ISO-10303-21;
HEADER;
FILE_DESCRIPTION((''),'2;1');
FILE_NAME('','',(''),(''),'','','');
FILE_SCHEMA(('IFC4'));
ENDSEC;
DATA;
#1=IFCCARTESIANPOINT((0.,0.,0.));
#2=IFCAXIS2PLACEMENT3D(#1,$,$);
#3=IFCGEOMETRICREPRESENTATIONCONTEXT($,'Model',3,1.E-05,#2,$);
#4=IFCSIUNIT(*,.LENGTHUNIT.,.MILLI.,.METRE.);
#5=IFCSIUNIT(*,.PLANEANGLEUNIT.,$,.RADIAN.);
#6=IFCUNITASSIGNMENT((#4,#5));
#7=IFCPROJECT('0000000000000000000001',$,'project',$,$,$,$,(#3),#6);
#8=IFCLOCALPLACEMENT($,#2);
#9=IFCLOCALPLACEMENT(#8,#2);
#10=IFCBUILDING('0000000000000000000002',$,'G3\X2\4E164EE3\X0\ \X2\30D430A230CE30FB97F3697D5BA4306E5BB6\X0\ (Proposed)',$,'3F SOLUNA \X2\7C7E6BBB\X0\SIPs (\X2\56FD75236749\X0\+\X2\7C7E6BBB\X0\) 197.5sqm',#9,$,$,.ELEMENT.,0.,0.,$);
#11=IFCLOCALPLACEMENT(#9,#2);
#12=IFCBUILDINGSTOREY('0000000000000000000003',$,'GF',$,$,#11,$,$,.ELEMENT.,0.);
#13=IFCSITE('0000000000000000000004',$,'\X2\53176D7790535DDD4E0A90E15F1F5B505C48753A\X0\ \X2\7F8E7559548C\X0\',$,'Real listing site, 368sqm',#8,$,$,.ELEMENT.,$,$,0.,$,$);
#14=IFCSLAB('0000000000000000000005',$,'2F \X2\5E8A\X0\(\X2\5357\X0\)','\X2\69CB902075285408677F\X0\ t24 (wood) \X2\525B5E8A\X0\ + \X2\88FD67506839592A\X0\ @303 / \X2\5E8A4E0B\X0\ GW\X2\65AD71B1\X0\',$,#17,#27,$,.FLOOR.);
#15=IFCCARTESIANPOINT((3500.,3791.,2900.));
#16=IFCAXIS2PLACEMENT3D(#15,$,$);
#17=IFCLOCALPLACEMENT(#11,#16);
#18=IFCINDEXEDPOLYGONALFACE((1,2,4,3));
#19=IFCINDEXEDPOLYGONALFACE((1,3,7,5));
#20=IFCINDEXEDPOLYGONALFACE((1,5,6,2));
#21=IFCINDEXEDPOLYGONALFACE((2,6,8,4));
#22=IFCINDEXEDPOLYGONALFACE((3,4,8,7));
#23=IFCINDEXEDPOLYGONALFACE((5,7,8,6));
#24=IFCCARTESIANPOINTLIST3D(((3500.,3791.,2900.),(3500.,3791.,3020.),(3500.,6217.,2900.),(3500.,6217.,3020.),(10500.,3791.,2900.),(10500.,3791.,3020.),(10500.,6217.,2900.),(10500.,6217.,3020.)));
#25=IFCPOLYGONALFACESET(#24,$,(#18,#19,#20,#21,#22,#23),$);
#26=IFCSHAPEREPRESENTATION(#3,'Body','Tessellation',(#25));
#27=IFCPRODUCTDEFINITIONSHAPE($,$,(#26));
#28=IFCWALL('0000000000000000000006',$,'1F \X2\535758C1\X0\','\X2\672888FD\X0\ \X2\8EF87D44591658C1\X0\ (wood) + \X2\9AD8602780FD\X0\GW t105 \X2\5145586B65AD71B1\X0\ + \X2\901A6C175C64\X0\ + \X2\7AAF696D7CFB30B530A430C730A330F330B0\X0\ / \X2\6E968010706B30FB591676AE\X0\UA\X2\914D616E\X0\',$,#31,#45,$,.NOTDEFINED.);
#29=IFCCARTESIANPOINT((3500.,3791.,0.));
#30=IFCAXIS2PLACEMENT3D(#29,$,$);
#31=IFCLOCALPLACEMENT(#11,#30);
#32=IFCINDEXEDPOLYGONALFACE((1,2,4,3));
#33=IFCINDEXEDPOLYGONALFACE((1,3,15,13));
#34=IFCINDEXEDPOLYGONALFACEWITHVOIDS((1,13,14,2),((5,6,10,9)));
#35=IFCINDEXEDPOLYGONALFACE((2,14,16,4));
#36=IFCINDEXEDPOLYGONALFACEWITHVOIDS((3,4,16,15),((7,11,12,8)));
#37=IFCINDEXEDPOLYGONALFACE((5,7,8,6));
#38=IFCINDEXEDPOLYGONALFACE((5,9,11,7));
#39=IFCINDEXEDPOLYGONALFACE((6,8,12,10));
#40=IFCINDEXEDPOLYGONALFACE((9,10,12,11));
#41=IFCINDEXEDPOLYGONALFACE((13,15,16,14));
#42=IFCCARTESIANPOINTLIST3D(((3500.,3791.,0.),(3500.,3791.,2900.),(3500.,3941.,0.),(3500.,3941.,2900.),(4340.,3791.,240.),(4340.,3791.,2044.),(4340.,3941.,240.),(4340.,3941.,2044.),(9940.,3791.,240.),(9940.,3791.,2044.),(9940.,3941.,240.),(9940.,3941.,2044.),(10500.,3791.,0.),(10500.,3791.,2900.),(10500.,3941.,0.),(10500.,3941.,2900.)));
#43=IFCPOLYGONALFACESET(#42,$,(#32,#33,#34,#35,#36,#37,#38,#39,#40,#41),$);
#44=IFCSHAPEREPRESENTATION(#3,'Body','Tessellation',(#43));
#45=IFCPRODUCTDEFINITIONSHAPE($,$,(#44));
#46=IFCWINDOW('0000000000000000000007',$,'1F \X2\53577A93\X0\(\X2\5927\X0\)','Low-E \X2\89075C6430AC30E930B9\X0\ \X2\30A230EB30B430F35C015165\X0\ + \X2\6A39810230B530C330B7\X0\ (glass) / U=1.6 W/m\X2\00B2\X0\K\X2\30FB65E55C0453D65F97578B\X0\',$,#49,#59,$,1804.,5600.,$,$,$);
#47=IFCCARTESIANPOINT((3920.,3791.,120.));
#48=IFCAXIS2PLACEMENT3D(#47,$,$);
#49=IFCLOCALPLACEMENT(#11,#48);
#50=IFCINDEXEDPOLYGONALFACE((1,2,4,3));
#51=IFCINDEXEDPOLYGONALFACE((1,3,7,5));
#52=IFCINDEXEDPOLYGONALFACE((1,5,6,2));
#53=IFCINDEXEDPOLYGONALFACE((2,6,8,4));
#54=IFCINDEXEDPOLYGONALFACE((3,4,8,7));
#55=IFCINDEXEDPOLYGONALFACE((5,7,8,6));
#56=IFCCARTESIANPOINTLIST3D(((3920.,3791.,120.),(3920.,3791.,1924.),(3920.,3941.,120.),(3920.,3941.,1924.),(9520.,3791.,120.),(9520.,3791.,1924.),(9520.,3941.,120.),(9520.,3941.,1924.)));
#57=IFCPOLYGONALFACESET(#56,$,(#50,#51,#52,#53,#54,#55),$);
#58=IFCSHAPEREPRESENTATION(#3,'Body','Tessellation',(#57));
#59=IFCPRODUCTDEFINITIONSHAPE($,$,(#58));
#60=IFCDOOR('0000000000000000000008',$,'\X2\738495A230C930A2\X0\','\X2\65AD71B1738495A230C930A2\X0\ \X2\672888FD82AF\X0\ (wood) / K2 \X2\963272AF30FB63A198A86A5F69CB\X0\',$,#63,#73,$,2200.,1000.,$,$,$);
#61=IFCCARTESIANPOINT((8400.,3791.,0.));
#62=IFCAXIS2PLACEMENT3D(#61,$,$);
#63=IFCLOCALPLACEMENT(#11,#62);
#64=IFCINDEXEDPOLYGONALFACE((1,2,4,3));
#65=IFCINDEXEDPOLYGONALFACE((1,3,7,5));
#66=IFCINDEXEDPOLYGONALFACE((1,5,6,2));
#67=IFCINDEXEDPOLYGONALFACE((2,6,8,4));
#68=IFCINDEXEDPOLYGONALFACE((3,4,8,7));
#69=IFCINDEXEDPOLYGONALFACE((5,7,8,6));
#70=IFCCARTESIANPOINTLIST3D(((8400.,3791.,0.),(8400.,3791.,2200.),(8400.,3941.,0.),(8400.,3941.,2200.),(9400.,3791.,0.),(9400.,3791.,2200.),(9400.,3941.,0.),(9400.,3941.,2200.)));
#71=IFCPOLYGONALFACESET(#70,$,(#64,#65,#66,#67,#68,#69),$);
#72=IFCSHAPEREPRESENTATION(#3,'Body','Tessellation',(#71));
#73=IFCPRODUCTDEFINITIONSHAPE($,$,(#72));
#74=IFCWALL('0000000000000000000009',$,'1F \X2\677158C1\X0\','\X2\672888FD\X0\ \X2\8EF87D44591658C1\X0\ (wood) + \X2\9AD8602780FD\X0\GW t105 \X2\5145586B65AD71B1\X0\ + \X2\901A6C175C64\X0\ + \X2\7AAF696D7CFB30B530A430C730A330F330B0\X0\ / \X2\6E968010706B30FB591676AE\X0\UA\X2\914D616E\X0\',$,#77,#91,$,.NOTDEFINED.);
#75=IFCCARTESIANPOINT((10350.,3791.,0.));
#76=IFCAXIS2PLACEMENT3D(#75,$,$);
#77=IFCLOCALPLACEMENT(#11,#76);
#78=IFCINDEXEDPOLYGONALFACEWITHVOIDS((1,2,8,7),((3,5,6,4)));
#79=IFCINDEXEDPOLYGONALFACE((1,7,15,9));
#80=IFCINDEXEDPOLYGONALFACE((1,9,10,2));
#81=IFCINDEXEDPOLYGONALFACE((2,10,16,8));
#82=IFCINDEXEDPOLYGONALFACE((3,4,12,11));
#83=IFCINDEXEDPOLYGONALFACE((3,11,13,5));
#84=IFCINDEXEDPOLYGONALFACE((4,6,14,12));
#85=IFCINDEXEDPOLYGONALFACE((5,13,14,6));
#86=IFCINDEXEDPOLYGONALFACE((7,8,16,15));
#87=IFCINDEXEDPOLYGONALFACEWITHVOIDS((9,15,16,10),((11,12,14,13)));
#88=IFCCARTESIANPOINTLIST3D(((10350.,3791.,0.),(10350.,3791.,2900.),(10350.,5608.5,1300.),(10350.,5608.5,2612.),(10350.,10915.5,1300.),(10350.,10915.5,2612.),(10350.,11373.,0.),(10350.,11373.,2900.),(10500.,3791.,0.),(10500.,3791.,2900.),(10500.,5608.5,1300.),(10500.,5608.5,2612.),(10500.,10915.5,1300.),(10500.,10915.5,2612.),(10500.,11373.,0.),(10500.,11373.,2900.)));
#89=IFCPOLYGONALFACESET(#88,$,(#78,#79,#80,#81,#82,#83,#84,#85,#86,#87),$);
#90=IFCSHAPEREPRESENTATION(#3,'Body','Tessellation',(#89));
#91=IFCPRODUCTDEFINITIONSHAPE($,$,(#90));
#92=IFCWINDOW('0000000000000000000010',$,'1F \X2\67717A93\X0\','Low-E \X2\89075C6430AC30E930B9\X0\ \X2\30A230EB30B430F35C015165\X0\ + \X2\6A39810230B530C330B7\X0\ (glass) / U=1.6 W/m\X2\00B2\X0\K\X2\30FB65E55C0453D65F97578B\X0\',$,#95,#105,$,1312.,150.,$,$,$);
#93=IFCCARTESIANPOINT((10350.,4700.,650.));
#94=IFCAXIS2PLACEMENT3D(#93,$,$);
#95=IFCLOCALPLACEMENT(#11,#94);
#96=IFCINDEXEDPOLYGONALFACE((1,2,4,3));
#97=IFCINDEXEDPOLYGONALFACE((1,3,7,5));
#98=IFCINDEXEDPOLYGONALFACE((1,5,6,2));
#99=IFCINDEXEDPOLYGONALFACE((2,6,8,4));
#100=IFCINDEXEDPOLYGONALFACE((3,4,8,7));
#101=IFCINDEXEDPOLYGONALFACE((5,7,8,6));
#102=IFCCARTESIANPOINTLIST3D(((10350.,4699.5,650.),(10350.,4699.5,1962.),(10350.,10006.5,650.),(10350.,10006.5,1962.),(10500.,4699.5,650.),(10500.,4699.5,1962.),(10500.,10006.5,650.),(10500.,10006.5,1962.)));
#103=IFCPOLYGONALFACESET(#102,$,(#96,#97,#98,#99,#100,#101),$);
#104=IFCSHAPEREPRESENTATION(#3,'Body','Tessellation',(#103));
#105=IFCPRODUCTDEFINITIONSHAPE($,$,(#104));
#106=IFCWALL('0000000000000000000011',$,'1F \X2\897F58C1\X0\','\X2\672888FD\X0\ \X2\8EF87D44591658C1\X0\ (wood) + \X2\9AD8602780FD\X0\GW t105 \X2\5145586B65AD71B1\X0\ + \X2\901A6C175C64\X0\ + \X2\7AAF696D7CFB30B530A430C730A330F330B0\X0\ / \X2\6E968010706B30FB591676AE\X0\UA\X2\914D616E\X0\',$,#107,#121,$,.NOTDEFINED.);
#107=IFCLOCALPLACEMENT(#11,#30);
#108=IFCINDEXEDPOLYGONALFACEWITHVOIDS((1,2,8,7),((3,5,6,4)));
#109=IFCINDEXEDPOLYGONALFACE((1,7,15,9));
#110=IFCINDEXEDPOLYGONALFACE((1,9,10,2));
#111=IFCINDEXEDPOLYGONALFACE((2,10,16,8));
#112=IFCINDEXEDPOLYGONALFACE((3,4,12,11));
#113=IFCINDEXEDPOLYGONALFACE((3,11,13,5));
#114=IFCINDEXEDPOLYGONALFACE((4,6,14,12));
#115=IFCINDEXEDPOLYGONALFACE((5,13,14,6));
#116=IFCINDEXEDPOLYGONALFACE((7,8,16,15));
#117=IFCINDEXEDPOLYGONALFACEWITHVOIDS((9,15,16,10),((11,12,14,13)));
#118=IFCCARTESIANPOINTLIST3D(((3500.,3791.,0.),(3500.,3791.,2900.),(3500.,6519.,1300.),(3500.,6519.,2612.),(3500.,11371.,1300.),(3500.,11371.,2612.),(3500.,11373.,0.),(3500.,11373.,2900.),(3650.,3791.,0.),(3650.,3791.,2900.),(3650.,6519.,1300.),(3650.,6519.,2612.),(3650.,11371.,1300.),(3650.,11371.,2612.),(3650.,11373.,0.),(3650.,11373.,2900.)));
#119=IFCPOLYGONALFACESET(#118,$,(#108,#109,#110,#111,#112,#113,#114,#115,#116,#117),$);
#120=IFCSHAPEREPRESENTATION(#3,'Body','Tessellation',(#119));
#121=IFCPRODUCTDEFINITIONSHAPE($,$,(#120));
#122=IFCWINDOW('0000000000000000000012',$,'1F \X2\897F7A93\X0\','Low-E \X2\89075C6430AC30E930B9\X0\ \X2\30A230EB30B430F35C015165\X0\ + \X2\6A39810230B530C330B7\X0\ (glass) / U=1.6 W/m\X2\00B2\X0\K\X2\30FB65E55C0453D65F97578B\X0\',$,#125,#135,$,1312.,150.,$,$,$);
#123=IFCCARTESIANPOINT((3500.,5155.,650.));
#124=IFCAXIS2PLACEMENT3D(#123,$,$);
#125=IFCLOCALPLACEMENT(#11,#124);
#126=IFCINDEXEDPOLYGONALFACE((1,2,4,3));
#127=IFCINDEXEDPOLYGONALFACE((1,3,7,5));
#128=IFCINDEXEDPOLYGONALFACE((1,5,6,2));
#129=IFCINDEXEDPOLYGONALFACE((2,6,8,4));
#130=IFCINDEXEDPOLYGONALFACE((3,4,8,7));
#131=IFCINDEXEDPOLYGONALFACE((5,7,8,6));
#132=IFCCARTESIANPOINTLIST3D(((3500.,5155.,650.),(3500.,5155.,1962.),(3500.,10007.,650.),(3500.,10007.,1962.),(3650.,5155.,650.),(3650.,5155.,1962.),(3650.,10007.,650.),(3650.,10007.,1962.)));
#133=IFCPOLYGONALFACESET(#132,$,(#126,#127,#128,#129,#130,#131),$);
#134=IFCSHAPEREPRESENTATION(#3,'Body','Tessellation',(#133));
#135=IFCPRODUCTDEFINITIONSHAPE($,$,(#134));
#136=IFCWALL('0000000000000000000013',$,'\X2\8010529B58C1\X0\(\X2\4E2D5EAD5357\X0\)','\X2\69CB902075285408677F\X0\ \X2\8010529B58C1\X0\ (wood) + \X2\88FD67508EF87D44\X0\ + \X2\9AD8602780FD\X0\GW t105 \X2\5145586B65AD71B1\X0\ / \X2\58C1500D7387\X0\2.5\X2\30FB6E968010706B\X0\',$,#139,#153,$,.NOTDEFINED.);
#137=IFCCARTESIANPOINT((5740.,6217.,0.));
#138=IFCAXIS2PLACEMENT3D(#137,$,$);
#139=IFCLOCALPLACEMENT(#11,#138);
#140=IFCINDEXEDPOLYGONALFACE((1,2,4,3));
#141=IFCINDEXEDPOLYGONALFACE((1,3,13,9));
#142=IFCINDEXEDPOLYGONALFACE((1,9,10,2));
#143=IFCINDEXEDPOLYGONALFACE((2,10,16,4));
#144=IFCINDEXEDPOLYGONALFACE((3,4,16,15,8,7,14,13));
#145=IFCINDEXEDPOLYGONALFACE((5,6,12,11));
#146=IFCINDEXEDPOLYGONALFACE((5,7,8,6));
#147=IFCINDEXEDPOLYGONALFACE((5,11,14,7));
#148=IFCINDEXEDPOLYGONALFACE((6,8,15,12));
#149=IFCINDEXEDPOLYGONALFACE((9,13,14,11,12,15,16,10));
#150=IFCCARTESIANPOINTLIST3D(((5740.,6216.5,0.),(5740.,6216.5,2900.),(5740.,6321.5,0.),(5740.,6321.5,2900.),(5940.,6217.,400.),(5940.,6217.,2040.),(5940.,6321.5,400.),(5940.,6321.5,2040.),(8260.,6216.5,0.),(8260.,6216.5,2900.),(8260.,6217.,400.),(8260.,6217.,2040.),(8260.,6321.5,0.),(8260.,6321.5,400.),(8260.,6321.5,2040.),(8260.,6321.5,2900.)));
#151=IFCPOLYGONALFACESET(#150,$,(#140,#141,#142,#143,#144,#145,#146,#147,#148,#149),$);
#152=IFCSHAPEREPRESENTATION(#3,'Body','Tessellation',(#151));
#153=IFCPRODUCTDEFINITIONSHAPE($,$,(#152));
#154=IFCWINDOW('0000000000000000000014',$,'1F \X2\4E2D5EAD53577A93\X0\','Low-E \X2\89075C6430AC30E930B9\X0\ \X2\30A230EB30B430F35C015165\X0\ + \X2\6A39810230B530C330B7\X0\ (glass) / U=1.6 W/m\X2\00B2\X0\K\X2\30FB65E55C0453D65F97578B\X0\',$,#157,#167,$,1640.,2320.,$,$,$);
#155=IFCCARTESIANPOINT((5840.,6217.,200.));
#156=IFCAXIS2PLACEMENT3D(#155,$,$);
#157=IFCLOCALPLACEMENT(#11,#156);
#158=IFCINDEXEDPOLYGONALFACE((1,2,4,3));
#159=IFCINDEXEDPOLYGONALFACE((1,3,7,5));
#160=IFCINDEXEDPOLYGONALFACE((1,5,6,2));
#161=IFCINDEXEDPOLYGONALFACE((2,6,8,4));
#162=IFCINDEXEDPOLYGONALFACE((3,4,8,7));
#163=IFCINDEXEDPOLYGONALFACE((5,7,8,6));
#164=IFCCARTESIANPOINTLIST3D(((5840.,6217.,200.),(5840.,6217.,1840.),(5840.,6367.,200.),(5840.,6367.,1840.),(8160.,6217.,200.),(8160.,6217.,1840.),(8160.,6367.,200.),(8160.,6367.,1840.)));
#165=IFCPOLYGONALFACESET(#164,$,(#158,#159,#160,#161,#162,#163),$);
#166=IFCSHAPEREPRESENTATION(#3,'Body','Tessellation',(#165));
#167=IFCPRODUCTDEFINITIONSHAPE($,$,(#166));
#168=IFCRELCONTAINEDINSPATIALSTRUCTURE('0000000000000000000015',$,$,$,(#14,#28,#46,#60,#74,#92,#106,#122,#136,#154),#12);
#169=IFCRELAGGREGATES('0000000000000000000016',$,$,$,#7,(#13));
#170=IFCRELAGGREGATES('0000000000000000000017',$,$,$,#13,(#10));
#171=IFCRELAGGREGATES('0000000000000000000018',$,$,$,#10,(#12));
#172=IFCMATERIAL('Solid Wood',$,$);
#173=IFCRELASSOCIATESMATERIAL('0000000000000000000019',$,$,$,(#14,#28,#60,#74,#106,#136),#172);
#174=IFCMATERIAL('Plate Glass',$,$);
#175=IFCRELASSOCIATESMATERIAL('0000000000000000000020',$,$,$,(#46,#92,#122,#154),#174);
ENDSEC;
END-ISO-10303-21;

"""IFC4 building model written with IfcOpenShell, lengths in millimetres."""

from ifc_helpers import new_model, si_unit, frame, frame_2d, origin, place, context, project, spatial, rectangle, extrude, material, element, fill, save


model = new_model("IFC4")

# Units and contexts
model_context = context("Model", 3, precision=1e-05, world=origin())
ifc_project = project(units=[si_unit("LENGTHUNIT", "METRE", prefix="MILLI"), si_unit("PLANEANGLEUNIT", "RADIAN")], contexts=[model_context])

# Site, building, storey
site_placement = place(None, origin())
site = spatial("IfcSite", under=ifc_project, at=site_placement, Name="北海道川上郡弟子屈町 美留和", ObjectType="Real listing site, 368sqm", CompositionType="ELEMENT", RefElevation=0.0)
building_placement = place(site_placement, origin())
building = spatial("IfcBuilding", under=site, at=building_placement, Name="G3世代 ピアノ・音楽室の家 (Proposed)", ObjectType="3F SOLUNA 籾殻SIPs (国産杉+籾殻) 197.5sqm", CompositionType="ELEMENT", ElevationOfRefHeight=0.0, ElevationOfTerrain=0.0)
storey_placement = place(building_placement, origin())
storey = spatial("IfcBuildingStorey", under=building, at=storey_placement, Name="GF", CompositionType="ELEMENT", Elevation=0.0)

# Slab
ifc_material_1 = material(Name="Solid Wood")
slab_1_placement = place(storey_placement, frame((3500.0, 3791.0, 2900.0)))
element("IfcSlab", 1, at=slab_1_placement, inside=storey, material=ifc_material_1, Name="2F 床(南)", Description="構造用合板 t24 (wood) 剛床 + 製材根太 @303 / 床下 GW断熱", PredefinedType="FLOOR", context=model_context, shape_type="SweptSolid", body=[
    extrude(rectangle(XDim=7000.0, YDim=2426.0, at=frame_2d((3500.0, 1213.0))), frame((3500.0, 3791.0, 2900.0)), (0.0, 0.0, 1.0), 120.0),
])

# Wall, openings, window, door
wall_1_placement = place(storey_placement, frame((3500.0, 3791.0, 0.0)))
wall_1 = element("IfcWall", 2, at=wall_1_placement, inside=storey, material=ifc_material_1, Name="1F 南壁", Description="木製 軸組外壁 (wood) + 高性能GW t105 充填断熱 + 通気層 + 窯業系サイディング / 準耐火・外皮UA配慮", PredefinedType="NOTDEFINED", context=model_context, shape_type="SweptSolid", body=[
    extrude(rectangle(XDim=7000.0, YDim=150.0, at=frame_2d((3500.0, 75.0))), frame((3500.0, 3791.0, 0.0)), (0.0, 0.0, 1.0), 2900.0),
])
opening_1_placement = place(storey_placement, frame((3920.0, 3791.0, 120.0)))
opening_1 = element("IfcOpeningElement", 3, at=opening_1_placement, cuts=wall_1, PredefinedType="NOTDEFINED", context=model_context, shape_type="SweptSolid", body=[
    extrude(rectangle(XDim=5600.0, YDim=150.0, at=frame_2d((2800.0, 75.0))), frame((3920.0, 3791.0, 120.0)), (0.0, 0.0, 1.0), 1804.0),
])
opening_2_placement = place(storey_placement, frame((8400.0, 3791.0, 0.0)))
opening_2 = element("IfcOpeningElement", 4, at=opening_2_placement, cuts=wall_1, PredefinedType="NOTDEFINED", context=model_context, shape_type="SweptSolid", body=[
    extrude(rectangle(XDim=1000.0, YDim=150.0, at=frame_2d((500.0, 75.0))), frame((8400.0, 3791.0, 0.0)), (0.0, 0.0, 1.0), 2200.0),
])
ifc_material_2 = material(Name="Plate Glass")
window_1_placement = place(storey_placement, frame((3920.0, 3791.0, 120.0)))
window_1 = element("IfcWindow", 5, at=window_1_placement, inside=storey, material=ifc_material_2, Name="1F 南窓(大)", Description="Low-E 複層ガラス アルゴン封入 + 樹脂サッシ (glass) / U=1.6 W/m²K・日射取得型", OverallHeight=1804.0, OverallWidth=5600.0, context=model_context, shape_type="SweptSolid", body=[
    extrude(rectangle(XDim=5600.0, YDim=150.0, at=frame_2d((2800.0, 75.0))), frame((3920.0, 3791.0, 120.0)), (0.0, 0.0, 1.0), 1804.0),
])
fill(opening_1, window_1)
door_placement = place(storey_placement, frame((8400.0, 3791.0, 0.0)))
door = element("IfcDoor", 6, at=door_placement, inside=storey, material=ifc_material_1, Name="玄関ドア", Description="断熱玄関ドア 木製芯 (wood) / K2 防犯・採風機構", OverallHeight=2200.0, OverallWidth=1000.0, context=model_context, shape_type="SweptSolid", body=[
    extrude(rectangle(XDim=1000.0, YDim=150.0, at=frame_2d((500.0, 75.0))), frame((8400.0, 3791.0, 0.0)), (0.0, 0.0, 1.0), 2200.0),
])
fill(opening_2, door)

# Walls, openings, windows
wall_2_placement = place(storey_placement, frame((10350.0, 3791.0, 0.0)))
wall_2 = element("IfcWall", 7, at=wall_2_placement, inside=storey, material=ifc_material_1, Name="1F 東壁", Description="木製 軸組外壁 (wood) + 高性能GW t105 充填断熱 + 通気層 + 窯業系サイディング / 準耐火・外皮UA配慮", PredefinedType="NOTDEFINED", context=model_context, shape_type="SweptSolid", body=[
    extrude(rectangle(XDim=150.0, YDim=7582.0, at=frame_2d((75.0, 3791.0))), frame((10350.0, 3791.0, 0.0)), (0.0, 0.0, 1.0), 2900.0),
])
opening_3_placement = place(storey_placement, frame((10350.0, 4700.0, 650.0)))
opening_3 = element("IfcOpeningElement", 8, at=opening_3_placement, cuts=wall_2, PredefinedType="NOTDEFINED", context=model_context, shape_type="SweptSolid", body=[
    extrude(rectangle(XDim=150.0, YDim=5307.0, at=frame_2d((75.0, 2653.0))), frame((10350.0, 4700.0, 650.0)), (0.0, 0.0, 1.0), 1312.0),
])
window_2_placement = place(storey_placement, frame((10350.0, 4700.0, 650.0)))
window_2 = element("IfcWindow", 9, at=window_2_placement, inside=storey, material=ifc_material_2, Name="1F 東窓", Description="Low-E 複層ガラス アルゴン封入 + 樹脂サッシ (glass) / U=1.6 W/m²K・日射取得型", OverallHeight=1312.0, OverallWidth=150.0, context=model_context, shape_type="SweptSolid", body=[
    extrude(rectangle(XDim=150.0, YDim=5307.0, at=frame_2d((75.0, 2653.0))), frame((10350.0, 4700.0, 650.0)), (0.0, 0.0, 1.0), 1312.0),
])
fill(opening_3, window_2)
wall_3_placement = place(storey_placement, frame((3500.0, 3791.0, 0.0)))
wall_3 = element("IfcWall", 10, at=wall_3_placement, inside=storey, material=ifc_material_1, Name="1F 西壁", Description="木製 軸組外壁 (wood) + 高性能GW t105 充填断熱 + 通気層 + 窯業系サイディング / 準耐火・外皮UA配慮", PredefinedType="NOTDEFINED", context=model_context, shape_type="SweptSolid", body=[
    extrude(rectangle(XDim=150.0, YDim=7582.0, at=frame_2d((75.0, 3791.0))), frame((3500.0, 3791.0, 0.0)), (0.0, 0.0, 1.0), 2900.0),
])
opening_4_placement = place(storey_placement, frame((3500.0, 5155.0, 650.0)))
opening_4 = element("IfcOpeningElement", 11, at=opening_4_placement, cuts=wall_3, PredefinedType="NOTDEFINED", context=model_context, shape_type="SweptSolid", body=[
    extrude(rectangle(XDim=150.0, YDim=4852.0, at=frame_2d((75.0, 2426.0))), frame((3500.0, 5155.0, 650.0)), (0.0, 0.0, 1.0), 1312.0),
])
window_3_placement = place(storey_placement, frame((3500.0, 5155.0, 650.0)))
window_3 = element("IfcWindow", 12, at=window_3_placement, inside=storey, material=ifc_material_2, Name="1F 西窓", Description="Low-E 複層ガラス アルゴン封入 + 樹脂サッシ (glass) / U=1.6 W/m²K・日射取得型", OverallHeight=1312.0, OverallWidth=150.0, context=model_context, shape_type="SweptSolid", body=[
    extrude(rectangle(XDim=150.0, YDim=4852.0, at=frame_2d((75.0, 2426.0))), frame((3500.0, 5155.0, 650.0)), (0.0, 0.0, 1.0), 1312.0),
])
fill(opening_4, window_3)
wall_4_placement = place(storey_placement, frame((5740.0, 6217.0, 0.0)))
wall_4 = element("IfcWall", 13, at=wall_4_placement, inside=storey, material=ifc_material_1, Name="耐力壁(中庭南)", Description="構造用合板 耐力壁 (wood) + 製材軸組 + 高性能GW t105 充填断熱 / 壁倍率2.5・準耐火", PredefinedType="NOTDEFINED", context=model_context, shape_type="SweptSolid", body=[
    extrude(rectangle(XDim=2520.0, YDim=105.0, at=frame_2d((1260.0, 52.0))), frame((5740.0, 6217.0, 0.0)), (0.0, 0.0, 1.0), 2900.0),
])
opening_5_placement = place(storey_placement, frame((5840.0, 6217.0, 200.0)))
opening_5 = element("IfcOpeningElement", 14, at=opening_5_placement, cuts=wall_4, PredefinedType="NOTDEFINED", context=model_context, shape_type="SweptSolid", body=[
    extrude(rectangle(XDim=2320.0, YDim=150.0, at=frame_2d((1160.0, 75.0))), frame((5840.0, 6217.0, 200.0)), (0.0, 0.0, 1.0), 1640.0),
])
window_4_placement = place(storey_placement, frame((5840.0, 6217.0, 200.0)))
window_4 = element("IfcWindow", 15, at=window_4_placement, inside=storey, material=ifc_material_2, Name="1F 中庭南窓", Description="Low-E 複層ガラス アルゴン封入 + 樹脂サッシ (glass) / U=1.6 W/m²K・日射取得型", OverallHeight=1640.0, OverallWidth=2320.0, context=model_context, shape_type="SweptSolid", body=[
    extrude(rectangle(XDim=2320.0, YDim=150.0, at=frame_2d((1160.0, 75.0))), frame((5840.0, 6217.0, 200.0)), (0.0, 0.0, 1.0), 1640.0),
])
fill(opening_5, window_4)

save(model, "model.ifc")
